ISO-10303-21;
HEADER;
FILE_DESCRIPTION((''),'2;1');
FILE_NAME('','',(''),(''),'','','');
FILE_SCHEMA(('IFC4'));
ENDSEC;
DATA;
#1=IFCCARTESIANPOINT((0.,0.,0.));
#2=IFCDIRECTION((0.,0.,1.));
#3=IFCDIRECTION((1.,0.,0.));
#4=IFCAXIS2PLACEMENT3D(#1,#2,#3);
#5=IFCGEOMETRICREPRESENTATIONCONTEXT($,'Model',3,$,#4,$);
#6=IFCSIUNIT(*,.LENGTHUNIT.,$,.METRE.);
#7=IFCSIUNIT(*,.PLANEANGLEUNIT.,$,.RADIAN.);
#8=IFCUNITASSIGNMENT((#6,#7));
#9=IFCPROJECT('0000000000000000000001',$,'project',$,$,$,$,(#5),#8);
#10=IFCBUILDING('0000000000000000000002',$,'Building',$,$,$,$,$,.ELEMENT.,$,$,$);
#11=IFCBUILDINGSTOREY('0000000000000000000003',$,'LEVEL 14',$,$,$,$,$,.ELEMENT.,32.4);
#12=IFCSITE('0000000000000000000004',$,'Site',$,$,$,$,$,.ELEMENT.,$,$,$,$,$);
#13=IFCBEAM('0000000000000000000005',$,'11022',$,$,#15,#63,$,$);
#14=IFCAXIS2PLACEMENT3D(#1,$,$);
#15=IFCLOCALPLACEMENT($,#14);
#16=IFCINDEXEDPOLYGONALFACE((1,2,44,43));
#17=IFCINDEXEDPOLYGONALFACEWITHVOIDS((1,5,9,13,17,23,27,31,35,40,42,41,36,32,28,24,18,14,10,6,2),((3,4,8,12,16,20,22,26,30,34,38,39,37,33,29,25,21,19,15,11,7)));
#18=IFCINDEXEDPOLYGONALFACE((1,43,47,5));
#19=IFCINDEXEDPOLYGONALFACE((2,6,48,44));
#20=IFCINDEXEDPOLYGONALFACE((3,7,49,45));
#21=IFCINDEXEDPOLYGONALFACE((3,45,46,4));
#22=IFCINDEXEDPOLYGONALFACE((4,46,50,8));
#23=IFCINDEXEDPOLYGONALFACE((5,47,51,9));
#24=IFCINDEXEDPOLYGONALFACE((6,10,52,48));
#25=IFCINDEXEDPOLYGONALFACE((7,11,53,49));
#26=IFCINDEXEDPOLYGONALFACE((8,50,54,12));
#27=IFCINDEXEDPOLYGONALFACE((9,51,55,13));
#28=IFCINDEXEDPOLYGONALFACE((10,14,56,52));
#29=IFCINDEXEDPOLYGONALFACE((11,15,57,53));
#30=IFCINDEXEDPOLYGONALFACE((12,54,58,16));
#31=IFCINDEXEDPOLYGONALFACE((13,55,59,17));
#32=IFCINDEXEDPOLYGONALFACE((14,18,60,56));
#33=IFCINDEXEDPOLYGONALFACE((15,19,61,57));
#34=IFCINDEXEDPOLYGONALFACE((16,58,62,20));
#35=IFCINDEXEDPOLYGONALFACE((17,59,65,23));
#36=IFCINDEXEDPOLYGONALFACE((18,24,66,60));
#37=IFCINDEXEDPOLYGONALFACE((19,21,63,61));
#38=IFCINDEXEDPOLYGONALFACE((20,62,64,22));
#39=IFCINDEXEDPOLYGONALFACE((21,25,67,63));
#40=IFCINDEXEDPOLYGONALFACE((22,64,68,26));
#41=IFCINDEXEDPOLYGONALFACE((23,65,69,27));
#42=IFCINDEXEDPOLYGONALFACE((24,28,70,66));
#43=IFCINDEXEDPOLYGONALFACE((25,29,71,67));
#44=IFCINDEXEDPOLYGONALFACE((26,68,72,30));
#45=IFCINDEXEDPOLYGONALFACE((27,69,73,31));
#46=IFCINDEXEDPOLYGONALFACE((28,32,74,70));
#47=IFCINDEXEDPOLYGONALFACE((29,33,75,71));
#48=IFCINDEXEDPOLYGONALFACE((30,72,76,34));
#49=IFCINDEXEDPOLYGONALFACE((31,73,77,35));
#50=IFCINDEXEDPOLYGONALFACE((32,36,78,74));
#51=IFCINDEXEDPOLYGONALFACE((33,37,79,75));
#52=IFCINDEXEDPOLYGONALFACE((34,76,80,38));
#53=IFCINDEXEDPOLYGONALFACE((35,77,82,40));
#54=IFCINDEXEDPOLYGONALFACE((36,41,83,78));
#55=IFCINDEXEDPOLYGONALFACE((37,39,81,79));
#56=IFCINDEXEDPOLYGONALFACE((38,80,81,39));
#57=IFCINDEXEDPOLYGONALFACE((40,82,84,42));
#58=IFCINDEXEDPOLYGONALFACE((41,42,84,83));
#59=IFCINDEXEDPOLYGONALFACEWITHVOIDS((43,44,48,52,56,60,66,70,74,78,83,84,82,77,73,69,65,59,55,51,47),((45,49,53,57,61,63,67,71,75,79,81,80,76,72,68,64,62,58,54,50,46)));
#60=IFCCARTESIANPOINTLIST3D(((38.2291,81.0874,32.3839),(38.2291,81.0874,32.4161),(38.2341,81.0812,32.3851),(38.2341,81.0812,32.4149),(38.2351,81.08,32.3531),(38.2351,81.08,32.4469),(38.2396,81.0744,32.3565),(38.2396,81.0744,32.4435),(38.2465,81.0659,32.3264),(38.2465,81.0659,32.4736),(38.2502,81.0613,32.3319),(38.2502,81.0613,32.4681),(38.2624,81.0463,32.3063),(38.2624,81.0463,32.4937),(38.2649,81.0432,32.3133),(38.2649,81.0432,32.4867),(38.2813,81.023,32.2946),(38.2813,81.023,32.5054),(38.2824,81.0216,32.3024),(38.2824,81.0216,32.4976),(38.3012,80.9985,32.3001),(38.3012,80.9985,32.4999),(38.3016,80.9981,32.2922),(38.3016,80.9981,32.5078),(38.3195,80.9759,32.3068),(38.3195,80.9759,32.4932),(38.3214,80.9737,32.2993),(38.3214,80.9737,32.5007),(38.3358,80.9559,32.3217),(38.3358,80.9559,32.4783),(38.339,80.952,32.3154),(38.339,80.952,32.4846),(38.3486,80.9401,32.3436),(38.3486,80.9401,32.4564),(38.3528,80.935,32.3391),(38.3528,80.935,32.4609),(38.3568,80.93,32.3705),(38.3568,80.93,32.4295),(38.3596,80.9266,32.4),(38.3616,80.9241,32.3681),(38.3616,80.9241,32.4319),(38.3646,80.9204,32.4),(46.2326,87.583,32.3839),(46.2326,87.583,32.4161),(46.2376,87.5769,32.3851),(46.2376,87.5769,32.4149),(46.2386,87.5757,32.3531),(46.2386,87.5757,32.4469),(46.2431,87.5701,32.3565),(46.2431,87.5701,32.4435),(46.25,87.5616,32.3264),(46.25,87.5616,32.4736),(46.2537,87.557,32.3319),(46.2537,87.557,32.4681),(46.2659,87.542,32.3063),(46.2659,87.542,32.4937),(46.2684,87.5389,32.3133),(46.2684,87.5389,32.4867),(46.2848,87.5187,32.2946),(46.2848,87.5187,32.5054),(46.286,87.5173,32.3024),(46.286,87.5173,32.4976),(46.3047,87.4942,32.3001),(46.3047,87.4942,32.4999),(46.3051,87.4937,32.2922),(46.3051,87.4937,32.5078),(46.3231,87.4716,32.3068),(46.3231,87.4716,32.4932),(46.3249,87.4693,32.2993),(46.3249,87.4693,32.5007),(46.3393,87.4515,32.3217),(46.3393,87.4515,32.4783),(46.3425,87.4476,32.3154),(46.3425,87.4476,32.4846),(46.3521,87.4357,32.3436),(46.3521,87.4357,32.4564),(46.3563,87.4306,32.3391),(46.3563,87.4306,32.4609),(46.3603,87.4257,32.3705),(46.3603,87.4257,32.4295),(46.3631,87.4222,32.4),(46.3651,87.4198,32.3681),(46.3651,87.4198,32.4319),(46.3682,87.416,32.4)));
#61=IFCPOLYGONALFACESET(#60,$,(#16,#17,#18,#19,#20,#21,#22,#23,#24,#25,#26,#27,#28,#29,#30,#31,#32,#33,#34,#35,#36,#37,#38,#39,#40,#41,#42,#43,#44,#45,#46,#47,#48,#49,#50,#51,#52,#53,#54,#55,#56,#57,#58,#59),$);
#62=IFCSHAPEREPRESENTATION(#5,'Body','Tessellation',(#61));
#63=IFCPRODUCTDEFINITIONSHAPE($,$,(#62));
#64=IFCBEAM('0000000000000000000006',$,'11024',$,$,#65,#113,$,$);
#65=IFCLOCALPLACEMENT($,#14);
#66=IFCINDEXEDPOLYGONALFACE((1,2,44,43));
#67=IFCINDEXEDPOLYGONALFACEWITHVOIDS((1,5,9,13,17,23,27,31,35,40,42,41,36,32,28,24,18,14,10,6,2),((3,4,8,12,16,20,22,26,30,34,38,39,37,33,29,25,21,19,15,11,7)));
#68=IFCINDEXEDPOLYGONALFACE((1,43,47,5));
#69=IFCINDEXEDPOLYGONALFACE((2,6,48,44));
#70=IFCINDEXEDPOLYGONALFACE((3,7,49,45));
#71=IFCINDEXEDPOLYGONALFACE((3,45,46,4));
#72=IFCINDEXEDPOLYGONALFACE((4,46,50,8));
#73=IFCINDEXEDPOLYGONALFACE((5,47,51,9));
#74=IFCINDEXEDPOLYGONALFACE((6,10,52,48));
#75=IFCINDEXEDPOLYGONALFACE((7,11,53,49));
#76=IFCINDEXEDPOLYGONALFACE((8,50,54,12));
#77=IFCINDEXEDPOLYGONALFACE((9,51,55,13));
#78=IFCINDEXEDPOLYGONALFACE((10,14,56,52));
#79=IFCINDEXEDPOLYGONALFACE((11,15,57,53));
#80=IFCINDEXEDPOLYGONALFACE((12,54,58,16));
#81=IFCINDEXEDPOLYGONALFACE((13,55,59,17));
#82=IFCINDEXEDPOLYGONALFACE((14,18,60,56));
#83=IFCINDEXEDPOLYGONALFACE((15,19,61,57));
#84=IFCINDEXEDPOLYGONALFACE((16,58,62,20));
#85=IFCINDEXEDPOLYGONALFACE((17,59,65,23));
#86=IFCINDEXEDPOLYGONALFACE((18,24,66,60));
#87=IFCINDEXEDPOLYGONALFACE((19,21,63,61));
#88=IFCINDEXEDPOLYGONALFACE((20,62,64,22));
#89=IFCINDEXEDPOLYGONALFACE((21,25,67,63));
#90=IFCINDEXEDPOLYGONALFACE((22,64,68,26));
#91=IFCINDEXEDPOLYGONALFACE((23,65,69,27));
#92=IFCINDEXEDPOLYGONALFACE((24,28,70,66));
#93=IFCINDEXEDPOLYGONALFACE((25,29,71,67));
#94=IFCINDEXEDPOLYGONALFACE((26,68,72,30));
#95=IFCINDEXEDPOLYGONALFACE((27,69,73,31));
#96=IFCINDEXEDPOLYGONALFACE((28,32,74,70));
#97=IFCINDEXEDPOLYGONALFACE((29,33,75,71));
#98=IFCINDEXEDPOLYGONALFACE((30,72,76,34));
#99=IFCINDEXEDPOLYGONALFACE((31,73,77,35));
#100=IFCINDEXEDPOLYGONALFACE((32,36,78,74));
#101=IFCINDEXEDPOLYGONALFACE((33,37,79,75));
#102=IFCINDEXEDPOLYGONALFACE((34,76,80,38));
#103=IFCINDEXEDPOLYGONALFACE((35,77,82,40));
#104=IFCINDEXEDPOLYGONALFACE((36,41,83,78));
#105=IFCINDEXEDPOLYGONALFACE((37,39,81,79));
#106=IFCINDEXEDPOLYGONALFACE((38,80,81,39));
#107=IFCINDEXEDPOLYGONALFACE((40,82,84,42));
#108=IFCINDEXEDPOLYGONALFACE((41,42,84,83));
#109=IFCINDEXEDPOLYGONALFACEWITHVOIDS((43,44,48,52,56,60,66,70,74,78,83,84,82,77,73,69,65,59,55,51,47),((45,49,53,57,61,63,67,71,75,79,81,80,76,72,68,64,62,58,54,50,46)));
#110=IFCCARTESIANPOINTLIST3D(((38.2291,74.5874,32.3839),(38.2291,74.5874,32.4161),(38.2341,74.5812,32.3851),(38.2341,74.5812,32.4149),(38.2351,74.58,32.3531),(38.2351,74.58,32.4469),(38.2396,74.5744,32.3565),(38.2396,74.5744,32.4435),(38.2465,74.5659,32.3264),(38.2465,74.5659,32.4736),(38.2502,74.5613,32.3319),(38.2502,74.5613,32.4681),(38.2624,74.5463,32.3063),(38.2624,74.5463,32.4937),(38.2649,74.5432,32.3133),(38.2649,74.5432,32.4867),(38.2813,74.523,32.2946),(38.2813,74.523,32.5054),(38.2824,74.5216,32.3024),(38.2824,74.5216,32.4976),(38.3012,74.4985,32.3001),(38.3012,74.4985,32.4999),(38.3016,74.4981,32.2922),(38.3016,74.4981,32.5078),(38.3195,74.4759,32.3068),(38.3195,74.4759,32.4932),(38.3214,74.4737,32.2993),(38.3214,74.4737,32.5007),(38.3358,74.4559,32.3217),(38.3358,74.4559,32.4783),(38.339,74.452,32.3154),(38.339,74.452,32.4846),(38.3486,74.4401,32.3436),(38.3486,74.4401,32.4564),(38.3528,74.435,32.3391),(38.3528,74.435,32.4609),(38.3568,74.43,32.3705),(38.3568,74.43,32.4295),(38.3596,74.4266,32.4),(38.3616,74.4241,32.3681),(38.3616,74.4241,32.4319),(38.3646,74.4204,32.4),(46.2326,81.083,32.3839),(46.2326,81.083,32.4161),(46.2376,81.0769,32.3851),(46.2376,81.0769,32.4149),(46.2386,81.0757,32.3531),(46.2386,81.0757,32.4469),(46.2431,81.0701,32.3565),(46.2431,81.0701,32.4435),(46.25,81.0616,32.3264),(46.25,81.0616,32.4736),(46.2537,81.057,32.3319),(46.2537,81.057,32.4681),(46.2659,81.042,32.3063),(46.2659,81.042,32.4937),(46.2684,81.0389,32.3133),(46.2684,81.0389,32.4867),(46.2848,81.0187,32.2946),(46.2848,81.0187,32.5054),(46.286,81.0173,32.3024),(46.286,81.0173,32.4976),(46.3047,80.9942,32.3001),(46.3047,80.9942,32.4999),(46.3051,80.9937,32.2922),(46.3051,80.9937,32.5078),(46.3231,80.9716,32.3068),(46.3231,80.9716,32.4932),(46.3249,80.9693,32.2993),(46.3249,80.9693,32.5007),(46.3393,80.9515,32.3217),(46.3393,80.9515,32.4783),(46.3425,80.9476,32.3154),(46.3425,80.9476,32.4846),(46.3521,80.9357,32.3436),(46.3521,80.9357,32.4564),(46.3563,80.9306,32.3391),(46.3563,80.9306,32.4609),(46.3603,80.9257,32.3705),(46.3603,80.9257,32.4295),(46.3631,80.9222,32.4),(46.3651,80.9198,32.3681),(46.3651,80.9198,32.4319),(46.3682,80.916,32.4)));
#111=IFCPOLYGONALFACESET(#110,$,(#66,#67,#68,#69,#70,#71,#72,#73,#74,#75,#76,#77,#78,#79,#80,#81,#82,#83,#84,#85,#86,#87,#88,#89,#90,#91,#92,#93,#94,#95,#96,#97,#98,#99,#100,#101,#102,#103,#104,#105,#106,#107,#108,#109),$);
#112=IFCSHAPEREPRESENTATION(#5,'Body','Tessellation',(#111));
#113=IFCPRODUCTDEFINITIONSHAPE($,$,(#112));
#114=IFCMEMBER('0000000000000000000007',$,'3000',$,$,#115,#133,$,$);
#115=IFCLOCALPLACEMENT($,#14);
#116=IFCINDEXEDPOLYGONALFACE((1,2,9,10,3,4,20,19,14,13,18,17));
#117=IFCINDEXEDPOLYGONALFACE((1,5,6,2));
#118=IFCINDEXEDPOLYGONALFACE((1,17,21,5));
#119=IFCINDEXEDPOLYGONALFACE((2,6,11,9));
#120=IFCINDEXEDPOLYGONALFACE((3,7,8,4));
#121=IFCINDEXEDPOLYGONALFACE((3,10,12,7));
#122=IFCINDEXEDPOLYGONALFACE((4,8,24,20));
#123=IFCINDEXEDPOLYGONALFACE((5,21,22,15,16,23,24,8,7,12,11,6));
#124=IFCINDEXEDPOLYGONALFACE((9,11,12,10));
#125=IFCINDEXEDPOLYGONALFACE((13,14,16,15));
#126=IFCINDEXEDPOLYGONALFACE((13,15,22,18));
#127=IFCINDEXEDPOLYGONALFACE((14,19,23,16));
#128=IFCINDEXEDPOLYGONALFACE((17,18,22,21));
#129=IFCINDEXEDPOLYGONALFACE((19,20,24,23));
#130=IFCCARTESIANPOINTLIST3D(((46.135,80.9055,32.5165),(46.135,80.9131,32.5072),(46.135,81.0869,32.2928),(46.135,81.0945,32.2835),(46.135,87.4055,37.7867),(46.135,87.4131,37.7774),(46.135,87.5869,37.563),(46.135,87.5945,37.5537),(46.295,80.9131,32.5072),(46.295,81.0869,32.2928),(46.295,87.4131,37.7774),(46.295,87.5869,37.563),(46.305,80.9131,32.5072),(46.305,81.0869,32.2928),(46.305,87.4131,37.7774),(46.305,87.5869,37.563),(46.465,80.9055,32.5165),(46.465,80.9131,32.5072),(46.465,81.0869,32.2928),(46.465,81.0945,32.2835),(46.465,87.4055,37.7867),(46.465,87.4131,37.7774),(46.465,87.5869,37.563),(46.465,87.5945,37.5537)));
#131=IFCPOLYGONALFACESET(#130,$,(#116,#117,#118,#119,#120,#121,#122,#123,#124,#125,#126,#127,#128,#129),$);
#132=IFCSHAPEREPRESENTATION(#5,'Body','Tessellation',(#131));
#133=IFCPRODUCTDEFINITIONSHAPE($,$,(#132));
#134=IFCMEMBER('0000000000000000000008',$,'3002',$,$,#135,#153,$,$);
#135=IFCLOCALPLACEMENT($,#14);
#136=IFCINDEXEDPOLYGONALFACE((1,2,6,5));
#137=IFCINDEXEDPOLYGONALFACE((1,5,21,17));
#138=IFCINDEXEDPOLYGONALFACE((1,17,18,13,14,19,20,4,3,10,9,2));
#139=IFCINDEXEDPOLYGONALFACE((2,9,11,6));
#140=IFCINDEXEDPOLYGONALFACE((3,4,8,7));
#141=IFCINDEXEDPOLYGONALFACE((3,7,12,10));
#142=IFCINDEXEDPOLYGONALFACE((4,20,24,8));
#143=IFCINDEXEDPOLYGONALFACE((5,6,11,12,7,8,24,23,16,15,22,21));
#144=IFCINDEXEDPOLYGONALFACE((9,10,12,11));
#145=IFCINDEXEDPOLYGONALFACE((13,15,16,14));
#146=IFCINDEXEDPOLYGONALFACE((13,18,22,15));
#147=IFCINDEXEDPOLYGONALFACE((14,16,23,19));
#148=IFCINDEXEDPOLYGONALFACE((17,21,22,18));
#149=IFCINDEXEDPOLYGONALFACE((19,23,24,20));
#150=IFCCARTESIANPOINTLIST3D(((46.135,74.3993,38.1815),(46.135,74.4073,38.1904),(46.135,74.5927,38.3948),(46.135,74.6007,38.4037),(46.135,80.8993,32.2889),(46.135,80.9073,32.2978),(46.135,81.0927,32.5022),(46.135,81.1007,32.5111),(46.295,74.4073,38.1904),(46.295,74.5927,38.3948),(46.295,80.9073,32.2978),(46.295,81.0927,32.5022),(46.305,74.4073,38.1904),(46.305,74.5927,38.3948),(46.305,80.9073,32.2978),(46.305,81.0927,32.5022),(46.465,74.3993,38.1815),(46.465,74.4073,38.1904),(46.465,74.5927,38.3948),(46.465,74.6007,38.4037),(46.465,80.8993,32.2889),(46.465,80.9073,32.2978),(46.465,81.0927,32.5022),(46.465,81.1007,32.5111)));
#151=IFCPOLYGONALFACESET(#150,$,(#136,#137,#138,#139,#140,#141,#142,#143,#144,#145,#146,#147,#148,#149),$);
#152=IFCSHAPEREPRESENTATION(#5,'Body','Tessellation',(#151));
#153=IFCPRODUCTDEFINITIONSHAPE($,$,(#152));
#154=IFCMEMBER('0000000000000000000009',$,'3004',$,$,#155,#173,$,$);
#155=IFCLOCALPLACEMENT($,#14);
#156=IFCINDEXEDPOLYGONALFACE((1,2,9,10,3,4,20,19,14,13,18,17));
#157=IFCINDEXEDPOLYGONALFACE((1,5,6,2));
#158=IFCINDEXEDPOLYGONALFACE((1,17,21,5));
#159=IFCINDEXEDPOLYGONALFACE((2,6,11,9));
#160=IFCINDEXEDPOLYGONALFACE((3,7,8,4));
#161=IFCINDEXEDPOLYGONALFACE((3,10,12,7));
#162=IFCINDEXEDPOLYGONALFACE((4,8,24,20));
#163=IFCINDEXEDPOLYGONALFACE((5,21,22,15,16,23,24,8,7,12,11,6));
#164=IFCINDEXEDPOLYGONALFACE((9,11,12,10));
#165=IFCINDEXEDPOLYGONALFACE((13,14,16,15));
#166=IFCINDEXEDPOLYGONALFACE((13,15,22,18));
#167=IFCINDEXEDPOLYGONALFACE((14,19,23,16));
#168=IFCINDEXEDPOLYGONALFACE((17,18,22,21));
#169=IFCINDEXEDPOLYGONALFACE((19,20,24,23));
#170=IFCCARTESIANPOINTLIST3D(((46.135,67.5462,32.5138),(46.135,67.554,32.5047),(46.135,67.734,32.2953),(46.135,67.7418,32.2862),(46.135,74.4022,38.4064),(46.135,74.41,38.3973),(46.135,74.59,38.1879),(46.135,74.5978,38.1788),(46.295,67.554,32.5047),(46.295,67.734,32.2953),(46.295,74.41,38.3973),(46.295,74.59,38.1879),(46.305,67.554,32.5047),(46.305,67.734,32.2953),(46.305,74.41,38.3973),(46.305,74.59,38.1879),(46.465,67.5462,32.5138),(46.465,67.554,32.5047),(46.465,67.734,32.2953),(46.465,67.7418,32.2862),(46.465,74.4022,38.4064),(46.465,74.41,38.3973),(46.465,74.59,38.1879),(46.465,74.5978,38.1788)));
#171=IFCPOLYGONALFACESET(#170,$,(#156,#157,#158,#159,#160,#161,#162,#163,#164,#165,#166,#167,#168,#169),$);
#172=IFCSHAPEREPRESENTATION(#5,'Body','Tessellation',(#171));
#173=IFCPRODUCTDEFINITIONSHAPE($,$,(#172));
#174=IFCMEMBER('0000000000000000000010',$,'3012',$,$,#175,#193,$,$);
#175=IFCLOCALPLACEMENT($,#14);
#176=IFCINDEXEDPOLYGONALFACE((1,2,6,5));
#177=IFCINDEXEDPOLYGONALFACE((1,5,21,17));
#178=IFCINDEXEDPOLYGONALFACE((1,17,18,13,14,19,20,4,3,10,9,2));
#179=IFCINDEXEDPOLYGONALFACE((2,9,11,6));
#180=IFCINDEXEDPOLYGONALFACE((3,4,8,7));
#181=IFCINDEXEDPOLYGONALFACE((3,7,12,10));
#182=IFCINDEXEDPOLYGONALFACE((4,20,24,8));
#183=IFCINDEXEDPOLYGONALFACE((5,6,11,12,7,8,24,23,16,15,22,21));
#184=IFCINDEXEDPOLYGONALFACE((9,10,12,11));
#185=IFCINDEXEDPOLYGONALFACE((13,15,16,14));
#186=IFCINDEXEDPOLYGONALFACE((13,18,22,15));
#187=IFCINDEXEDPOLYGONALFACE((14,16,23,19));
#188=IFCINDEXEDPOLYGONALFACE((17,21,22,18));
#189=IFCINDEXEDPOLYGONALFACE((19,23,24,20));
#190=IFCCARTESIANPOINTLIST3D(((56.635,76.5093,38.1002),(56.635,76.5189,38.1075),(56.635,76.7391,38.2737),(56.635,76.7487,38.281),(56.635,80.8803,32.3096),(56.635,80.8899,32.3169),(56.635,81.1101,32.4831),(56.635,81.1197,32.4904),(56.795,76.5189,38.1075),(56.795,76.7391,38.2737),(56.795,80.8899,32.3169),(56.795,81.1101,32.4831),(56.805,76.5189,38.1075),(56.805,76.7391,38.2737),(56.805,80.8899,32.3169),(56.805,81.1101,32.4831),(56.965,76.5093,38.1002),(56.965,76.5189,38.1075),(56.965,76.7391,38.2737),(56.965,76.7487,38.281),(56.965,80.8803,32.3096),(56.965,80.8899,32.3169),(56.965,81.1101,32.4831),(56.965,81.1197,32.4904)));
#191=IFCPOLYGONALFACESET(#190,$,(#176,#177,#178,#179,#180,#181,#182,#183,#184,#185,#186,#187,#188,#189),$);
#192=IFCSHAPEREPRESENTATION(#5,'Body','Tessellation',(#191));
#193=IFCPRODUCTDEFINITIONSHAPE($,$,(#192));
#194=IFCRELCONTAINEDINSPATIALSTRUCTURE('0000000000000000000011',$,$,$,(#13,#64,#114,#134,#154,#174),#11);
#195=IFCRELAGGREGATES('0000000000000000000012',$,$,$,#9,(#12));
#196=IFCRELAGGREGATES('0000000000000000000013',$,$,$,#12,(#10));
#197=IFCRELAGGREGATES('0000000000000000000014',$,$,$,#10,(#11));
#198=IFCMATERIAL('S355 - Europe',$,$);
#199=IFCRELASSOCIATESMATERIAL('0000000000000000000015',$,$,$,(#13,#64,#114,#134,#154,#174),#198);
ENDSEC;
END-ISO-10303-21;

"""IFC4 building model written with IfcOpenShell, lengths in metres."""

from ifc_helpers import new_model, si_unit, frame, origin_with_axes, origin_2d_with_axis, place, context, project, spatial, hollow_circle, i_section, extrude, material, material_profile, profile_set, profile_usage, element, save


model = new_model("IFC4")

# Units and contexts
model_context = context("Model", 3, world=origin_with_axes())
ifc_project = project(units=[si_unit("LENGTHUNIT", "METRE"), si_unit("PLANEANGLEUNIT", "RADIAN")], contexts=[model_context])

# Site, building, storey
site = spatial("IfcSite", under=ifc_project, Name="Site", CompositionType="ELEMENT")
building = spatial("IfcBuilding", under=site, Name="Building", CompositionType="ELEMENT")
storey = spatial("IfcBuildingStorey", under=building, Name="LEVEL 14", CompositionType="ELEMENT", Elevation=32.4)

# Shared definitions
ifc_material = material(Name="S355 - Europe")

# Beams
ifc_material_profile_1 = material_profile(ifc_material, hollow_circle(Radius=0.1081, WallThickness=0.008, at=origin_2d_with_axis()))
ifc_profile_set_1 = profile_set([ifc_material_profile_1])
ifc_profile_usage_1 = profile_usage(ifc_profile_set_1, cardinal=10)
beam_1_placement = place(None, frame((46.3, 87.5, 32.4), z_axis=(-0.776456, -0.630172, 0.0), x_axis=(0.630071, -0.776537, 0.0)))
element("IfcBeam", 1, at=beam_1_placement, inside=storey, material=ifc_profile_usage_1, Name="11022", context=model_context, shape_type="SweptSolid", body=[
    extrude(hollow_circle(Radius=0.1081, WallThickness=0.008, at=origin_2d_with_axis()), origin_with_axes(), (0.0, 0.0, 1.0), 10.3078),
])
ifc_material_profile_2 = material_profile(ifc_material, hollow_circle(Radius=0.1081, WallThickness=0.008, at=origin_2d_with_axis()))
ifc_profile_set_2 = profile_set([ifc_material_profile_2])
ifc_profile_usage_2 = profile_usage(ifc_profile_set_2, cardinal=10)
beam_2_placement = place(None, frame((46.3, 81.0, 32.4), z_axis=(-0.776456, -0.630172, 0.0), x_axis=(0.630071, -0.776537, 0.0)))
element("IfcBeam", 2, at=beam_2_placement, inside=storey, material=ifc_profile_usage_2, Name="11024", context=model_context, shape_type="SweptSolid", body=[
    extrude(hollow_circle(Radius=0.1081, WallThickness=0.008, at=origin_2d_with_axis()), origin_with_axes(), (0.0, 0.0, 1.0), 10.3078),
])

# Members
ifc_material_profile_3 = material_profile(ifc_material, i_section(OverallWidth=0.33, OverallDepth=0.3, WebThickness=0.01, FlangeThickness=0.012, at=origin_2d_with_axis()))
ifc_profile_set_3 = profile_set([ifc_material_profile_3])
ifc_profile_usage_3 = profile_usage(ifc_profile_set_3, cardinal=10)
member_1_placement = place(None, frame((46.3, 87.5, 37.6702), z_axis=(0.0, -0.77676, -0.629797), x_axis=(1.0, 0.0, 0.0)))
element("IfcMember", 3, at=member_1_placement, inside=storey, material=ifc_profile_usage_3, Name="3000", context=model_context, shape_type="SweptSolid", body=[
    extrude(i_section(OverallWidth=0.33, OverallDepth=0.3, WebThickness=0.01, FlangeThickness=0.012, at=origin_2d_with_axis()), origin_with_axes(), (0.0, 0.0, 1.0), 8.3681),
])
ifc_material_profile_4 = material_profile(ifc_material, i_section(OverallWidth=0.33, OverallDepth=0.3, WebThickness=0.01, FlangeThickness=0.012, at=origin_2d_with_axis()))
ifc_profile_set_4 = profile_set([ifc_material_profile_4])
ifc_profile_usage_4 = profile_usage(ifc_profile_set_4, cardinal=10)
member_2_placement = place(None, frame((46.3, 81.0, 32.4), z_axis=(0.0, -0.740875, 0.671643), x_axis=(1.0, 0.0, 0.0)))
element("IfcMember", 4, at=member_2_placement, inside=storey, material=ifc_profile_usage_4, Name="3002", context=model_context, shape_type="SweptSolid", body=[
    extrude(i_section(OverallWidth=0.33, OverallDepth=0.3, WebThickness=0.01, FlangeThickness=0.012, at=origin_2d_with_axis()), origin_with_axes(), (0.0, 0.0, 1.0), 8.7734),
])
ifc_material_profile_5 = material_profile(ifc_material, i_section(OverallWidth=0.33, OverallDepth=0.3, WebThickness=0.01, FlangeThickness=0.012, at=origin_2d_with_axis()))
ifc_profile_set_5 = profile_set([ifc_material_profile_5])
ifc_profile_usage_5 = profile_usage(ifc_profile_set_5, cardinal=10)
member_3_placement = place(None, frame((46.3, 74.5, 38.2926), z_axis=(0.0, -0.75838, -0.651813), x_axis=(1.0, 0.0, 0.0)))
element("IfcMember", 5, at=member_3_placement, inside=storey, material=ifc_profile_usage_5, Name="3004", context=model_context, shape_type="SweptSolid", body=[
    extrude(i_section(OverallWidth=0.33, OverallDepth=0.3, WebThickness=0.01, FlangeThickness=0.012, at=origin_2d_with_axis()), origin_with_axes(), (0.0, 0.0, 1.0), 9.0403),
])
ifc_material_profile_6 = material_profile(ifc_material, i_section(OverallWidth=0.33, OverallDepth=0.3, WebThickness=0.01, FlangeThickness=0.012, at=origin_2d_with_axis()))
ifc_profile_set_6 = profile_set([ifc_material_profile_6])
ifc_profile_usage_6 = profile_usage(ifc_profile_set_6, cardinal=10)
member_4_placement = place(None, frame((56.8, 81.0, 32.4), z_axis=(0.0, -0.602472, 0.79814), x_axis=(1.0, 0.0, 0.0)))
element("IfcMember", 6, at=member_4_placement, inside=storey, material=ifc_profile_usage_6, Name="3012", context=model_context, shape_type="SweptSolid", body=[
    extrude(i_section(OverallWidth=0.33, OverallDepth=0.3, WebThickness=0.01, FlangeThickness=0.012, at=origin_2d_with_axis()), origin_with_axes(), (0.0, 0.0, 1.0), 7.2551),
])

save(model, "model.ifc")
